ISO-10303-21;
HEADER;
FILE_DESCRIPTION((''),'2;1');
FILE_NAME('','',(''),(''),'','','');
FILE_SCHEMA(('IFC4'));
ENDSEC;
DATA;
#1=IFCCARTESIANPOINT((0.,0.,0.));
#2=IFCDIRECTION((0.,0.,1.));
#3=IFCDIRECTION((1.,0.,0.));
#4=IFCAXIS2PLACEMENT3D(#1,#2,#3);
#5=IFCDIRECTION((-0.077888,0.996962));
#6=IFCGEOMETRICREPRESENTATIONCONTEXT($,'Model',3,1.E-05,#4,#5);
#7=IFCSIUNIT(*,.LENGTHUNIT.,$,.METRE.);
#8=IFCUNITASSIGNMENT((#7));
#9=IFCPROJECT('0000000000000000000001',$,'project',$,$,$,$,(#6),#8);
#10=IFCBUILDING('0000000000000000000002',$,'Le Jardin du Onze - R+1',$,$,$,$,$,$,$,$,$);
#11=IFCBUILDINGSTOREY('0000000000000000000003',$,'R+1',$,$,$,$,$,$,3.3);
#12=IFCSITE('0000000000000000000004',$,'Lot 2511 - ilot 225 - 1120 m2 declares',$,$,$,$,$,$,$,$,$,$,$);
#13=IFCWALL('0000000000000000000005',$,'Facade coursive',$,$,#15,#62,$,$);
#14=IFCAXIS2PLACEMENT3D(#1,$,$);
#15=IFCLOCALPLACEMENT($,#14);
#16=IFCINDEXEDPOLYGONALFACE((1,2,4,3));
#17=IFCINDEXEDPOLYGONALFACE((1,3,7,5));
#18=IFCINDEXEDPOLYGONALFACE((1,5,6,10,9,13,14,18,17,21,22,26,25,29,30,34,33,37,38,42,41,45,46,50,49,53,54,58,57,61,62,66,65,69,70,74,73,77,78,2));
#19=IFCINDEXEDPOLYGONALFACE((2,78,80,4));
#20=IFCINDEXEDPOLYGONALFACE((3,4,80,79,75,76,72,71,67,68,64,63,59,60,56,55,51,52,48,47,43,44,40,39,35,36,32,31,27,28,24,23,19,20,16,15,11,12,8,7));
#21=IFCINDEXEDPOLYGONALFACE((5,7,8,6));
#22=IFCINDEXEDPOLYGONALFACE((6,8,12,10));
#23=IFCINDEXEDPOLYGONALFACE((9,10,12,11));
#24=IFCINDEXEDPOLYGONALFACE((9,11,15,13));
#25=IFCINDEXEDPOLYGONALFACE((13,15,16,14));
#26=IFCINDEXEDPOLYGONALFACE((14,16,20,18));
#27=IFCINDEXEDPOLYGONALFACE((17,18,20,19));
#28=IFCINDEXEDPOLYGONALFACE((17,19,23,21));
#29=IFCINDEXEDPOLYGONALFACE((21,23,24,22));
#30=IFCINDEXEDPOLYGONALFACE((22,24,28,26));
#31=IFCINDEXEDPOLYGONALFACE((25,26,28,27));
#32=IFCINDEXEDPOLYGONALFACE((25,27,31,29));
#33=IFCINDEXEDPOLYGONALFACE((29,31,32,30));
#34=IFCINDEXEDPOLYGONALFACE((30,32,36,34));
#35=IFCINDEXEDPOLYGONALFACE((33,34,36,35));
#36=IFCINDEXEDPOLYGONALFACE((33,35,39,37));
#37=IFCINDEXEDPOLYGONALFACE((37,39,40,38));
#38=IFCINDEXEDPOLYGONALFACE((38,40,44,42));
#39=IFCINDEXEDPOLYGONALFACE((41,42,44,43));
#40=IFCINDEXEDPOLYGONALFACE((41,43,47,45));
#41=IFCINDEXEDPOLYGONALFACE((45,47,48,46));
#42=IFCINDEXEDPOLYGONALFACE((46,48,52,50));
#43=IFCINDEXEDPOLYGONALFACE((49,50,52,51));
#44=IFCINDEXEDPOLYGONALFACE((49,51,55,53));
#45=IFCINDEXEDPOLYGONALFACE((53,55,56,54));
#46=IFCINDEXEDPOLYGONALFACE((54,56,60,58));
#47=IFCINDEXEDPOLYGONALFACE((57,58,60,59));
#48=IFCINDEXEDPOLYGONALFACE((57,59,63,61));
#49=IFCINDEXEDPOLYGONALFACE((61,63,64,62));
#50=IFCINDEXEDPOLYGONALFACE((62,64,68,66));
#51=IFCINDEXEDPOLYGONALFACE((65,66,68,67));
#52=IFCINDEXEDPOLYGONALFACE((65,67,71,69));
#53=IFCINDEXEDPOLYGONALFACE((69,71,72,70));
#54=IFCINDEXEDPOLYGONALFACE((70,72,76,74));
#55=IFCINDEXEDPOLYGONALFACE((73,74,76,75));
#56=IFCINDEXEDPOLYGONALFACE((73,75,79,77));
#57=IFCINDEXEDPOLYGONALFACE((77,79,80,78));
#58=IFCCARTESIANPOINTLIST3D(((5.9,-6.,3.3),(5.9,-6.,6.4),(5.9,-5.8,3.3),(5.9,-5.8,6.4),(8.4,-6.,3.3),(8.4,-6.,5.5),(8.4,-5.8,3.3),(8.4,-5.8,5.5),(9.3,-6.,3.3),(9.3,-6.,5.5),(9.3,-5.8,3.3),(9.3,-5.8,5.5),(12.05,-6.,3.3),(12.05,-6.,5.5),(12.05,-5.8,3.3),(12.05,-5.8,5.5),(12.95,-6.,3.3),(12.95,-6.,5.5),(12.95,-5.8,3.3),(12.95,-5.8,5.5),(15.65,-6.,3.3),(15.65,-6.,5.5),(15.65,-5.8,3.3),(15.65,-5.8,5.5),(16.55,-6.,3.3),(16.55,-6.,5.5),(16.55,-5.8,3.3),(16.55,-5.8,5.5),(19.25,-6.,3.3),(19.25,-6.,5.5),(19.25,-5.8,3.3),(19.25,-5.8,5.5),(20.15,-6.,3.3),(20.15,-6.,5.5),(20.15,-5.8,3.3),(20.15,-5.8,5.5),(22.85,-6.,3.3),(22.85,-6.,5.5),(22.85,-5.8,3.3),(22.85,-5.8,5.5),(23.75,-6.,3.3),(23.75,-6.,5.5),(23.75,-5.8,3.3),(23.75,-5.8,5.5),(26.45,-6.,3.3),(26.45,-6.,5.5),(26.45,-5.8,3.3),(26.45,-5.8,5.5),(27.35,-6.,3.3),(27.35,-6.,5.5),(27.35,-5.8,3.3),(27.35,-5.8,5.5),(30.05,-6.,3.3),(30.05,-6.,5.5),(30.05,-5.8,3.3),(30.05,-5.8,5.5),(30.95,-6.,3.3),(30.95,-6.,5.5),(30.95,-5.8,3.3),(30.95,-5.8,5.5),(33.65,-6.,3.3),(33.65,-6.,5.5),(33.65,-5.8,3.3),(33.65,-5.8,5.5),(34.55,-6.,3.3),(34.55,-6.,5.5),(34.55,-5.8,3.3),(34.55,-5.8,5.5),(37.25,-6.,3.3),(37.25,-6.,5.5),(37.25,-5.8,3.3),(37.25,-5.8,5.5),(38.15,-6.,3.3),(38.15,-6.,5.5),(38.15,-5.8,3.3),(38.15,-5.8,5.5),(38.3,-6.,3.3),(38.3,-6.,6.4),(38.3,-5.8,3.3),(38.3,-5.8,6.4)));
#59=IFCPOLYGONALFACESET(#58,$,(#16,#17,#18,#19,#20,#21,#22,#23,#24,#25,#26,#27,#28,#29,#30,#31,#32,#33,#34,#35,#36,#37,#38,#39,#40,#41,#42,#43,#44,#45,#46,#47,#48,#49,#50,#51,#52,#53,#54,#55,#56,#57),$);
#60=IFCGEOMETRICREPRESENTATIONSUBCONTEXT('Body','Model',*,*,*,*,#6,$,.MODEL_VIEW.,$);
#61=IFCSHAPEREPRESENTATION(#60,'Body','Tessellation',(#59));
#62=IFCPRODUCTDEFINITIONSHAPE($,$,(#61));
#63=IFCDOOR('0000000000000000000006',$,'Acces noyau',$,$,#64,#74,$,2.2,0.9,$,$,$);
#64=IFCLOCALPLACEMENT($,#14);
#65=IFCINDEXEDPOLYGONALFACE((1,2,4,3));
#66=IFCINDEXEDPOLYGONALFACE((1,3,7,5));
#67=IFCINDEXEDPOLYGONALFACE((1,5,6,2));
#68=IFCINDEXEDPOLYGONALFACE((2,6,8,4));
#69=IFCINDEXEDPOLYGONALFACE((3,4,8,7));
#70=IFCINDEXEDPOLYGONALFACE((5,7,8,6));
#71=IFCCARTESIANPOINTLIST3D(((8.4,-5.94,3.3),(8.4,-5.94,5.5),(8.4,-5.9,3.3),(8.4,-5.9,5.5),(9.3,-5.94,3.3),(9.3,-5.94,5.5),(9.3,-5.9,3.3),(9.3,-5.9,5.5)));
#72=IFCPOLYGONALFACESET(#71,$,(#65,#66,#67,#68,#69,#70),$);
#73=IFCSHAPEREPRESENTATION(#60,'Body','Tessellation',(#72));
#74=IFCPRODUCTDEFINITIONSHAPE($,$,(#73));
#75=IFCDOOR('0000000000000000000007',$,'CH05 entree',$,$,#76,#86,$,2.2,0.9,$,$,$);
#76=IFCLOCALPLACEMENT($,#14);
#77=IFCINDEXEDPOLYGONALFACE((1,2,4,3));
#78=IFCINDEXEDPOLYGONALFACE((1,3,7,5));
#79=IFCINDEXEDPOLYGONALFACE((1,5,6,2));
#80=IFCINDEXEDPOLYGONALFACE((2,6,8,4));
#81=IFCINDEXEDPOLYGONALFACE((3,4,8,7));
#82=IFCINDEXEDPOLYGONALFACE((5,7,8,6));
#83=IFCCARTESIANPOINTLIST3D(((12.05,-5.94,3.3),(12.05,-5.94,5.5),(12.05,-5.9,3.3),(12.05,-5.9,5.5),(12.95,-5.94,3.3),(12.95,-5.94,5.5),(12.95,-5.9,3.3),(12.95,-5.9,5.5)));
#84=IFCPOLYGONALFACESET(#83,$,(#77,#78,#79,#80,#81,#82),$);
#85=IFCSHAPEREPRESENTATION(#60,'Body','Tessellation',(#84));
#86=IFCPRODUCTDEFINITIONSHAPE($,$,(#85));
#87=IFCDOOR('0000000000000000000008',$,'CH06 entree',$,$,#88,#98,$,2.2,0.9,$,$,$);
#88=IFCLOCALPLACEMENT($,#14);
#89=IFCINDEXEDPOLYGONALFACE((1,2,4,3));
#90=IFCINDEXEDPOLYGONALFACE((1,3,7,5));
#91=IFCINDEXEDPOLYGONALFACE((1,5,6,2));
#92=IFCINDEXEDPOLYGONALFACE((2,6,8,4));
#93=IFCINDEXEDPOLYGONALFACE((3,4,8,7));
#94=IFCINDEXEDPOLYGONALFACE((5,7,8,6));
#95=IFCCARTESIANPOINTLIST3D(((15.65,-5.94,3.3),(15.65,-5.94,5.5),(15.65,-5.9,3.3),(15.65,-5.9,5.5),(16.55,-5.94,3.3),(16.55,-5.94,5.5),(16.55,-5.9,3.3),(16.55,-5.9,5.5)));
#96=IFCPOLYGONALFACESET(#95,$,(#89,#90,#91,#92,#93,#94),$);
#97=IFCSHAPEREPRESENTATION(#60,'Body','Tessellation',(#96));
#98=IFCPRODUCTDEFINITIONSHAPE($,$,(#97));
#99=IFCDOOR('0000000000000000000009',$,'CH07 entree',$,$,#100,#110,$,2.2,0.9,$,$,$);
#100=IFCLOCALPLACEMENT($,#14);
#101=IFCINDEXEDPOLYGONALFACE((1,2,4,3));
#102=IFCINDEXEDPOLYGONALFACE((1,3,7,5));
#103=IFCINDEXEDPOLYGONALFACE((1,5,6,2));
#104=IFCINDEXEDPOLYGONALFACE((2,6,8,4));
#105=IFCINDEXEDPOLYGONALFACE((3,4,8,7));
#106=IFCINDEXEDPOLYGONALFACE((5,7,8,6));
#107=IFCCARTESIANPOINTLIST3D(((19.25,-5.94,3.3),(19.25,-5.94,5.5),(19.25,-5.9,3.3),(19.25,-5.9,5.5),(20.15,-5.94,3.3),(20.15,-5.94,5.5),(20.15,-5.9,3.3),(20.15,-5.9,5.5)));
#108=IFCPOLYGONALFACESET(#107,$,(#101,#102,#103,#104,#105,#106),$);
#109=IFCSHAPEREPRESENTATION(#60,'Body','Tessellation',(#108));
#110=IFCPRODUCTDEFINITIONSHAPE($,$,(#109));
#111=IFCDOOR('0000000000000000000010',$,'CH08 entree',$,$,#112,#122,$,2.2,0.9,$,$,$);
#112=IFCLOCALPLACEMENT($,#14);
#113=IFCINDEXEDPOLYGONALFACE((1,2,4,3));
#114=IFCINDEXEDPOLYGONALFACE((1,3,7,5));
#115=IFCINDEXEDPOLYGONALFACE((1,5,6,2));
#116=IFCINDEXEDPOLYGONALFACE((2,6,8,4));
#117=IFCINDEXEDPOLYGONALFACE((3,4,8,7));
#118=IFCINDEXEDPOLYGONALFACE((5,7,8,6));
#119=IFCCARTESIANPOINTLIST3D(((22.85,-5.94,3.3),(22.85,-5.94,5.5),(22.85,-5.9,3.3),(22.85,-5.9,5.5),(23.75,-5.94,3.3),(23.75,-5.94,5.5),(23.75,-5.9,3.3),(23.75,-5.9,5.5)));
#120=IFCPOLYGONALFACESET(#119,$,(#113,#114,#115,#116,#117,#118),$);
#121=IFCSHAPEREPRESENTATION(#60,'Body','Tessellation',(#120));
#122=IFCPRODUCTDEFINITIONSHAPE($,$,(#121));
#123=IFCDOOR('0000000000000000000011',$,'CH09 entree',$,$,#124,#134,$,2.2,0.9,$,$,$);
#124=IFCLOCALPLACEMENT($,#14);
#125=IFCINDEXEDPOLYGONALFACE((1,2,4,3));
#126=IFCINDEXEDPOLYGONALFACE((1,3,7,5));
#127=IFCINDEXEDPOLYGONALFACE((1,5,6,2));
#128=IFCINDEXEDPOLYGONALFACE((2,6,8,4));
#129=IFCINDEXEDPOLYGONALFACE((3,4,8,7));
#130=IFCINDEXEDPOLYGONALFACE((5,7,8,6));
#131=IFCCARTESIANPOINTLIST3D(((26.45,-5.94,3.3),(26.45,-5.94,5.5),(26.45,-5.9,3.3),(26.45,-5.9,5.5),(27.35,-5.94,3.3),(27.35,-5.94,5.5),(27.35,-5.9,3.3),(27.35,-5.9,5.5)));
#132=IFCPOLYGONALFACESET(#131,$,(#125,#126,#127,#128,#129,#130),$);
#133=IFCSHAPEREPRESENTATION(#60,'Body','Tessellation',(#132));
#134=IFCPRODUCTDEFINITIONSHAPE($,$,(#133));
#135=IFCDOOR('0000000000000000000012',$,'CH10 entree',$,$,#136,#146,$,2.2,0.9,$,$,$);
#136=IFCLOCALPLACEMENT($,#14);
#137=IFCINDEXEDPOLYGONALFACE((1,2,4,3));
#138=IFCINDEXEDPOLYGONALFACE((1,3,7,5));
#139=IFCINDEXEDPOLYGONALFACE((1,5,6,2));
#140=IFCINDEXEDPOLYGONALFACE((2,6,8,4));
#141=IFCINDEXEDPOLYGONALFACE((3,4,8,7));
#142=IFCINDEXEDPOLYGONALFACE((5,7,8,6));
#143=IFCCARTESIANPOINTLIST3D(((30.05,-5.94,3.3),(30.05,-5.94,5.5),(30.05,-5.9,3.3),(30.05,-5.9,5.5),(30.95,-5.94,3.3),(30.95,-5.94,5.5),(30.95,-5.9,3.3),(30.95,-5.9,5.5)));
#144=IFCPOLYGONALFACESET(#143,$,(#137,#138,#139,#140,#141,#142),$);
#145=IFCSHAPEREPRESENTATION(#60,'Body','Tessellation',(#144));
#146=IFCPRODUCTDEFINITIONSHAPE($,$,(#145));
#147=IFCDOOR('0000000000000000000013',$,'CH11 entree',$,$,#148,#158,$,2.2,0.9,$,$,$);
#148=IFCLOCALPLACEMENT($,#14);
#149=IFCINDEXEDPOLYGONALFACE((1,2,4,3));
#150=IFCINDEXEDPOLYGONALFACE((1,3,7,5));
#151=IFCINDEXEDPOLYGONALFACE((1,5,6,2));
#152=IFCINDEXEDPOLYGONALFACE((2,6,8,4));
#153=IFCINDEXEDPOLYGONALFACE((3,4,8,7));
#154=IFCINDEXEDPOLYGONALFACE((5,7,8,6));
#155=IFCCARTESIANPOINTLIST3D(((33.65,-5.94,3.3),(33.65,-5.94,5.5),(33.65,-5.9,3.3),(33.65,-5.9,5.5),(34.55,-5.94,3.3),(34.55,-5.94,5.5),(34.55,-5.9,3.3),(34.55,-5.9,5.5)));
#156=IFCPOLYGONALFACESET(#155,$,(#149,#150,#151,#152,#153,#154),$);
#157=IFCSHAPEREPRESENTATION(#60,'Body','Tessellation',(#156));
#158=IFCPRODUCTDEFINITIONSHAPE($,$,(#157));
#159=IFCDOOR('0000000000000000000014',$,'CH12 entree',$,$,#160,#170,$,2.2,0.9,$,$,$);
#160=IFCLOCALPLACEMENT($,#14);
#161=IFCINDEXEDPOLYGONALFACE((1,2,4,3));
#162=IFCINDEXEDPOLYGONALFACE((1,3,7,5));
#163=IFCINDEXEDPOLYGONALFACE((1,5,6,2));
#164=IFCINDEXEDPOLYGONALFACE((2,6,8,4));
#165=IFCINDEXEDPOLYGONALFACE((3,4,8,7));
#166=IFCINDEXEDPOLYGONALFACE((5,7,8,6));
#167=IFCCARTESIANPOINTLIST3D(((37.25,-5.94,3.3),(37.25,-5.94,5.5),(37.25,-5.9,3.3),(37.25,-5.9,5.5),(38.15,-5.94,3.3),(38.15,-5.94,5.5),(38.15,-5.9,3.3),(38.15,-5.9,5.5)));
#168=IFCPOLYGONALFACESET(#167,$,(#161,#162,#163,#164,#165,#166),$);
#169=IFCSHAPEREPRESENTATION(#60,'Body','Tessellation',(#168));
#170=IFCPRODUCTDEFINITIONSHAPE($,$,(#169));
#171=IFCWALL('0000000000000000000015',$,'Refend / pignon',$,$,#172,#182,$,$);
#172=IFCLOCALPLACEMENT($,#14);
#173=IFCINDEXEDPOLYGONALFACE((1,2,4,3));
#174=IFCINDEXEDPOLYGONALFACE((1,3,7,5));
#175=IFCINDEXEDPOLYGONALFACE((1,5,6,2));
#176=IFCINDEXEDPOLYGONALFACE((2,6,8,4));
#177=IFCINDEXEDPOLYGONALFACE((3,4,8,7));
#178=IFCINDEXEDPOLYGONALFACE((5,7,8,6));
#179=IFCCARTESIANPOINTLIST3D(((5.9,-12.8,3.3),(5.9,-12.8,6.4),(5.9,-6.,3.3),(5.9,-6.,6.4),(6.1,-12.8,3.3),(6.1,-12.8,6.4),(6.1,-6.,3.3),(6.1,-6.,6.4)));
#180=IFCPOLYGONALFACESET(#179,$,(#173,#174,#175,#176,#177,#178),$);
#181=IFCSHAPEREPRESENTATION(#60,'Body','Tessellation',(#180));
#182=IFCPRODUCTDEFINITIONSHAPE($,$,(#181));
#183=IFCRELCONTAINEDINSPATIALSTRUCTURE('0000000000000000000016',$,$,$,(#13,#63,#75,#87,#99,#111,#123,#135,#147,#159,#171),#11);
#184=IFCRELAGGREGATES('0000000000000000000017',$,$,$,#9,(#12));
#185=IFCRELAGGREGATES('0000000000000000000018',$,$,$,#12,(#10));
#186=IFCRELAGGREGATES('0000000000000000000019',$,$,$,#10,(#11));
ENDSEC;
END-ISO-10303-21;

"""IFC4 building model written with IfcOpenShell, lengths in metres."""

from ifc_helpers import new_model, si_unit, direction, frame, origin_with_axes, place, context, subcontext, project, spatial, polyline, outline, extrude, element, fill, save


model = new_model("IFC4")

# Units and contexts
model_context = context("Model", 3, precision=1e-05, world=origin_with_axes(), true_north=direction((-0.077888, 0.996962)))
body_context = subcontext(model_context, "Body", "Model", "MODEL_VIEW")
ifc_project = project(units=[si_unit("LENGTHUNIT", "METRE")], contexts=[model_context])

# Site, building, storey
site = spatial("IfcSite", under=ifc_project, Name="Lot 2511 - ilot 225 - 1120 m2 declares")
building = spatial("IfcBuilding", under=site, Name="Le Jardin du Onze - R+1")
storey = spatial("IfcBuildingStorey", under=building, Name="R+1", Elevation=3.3)

# Wall, openings, doors
wall_1_placement = place(None, origin_with_axes())
wall_1 = element("IfcWall", 1, at=wall_1_placement, inside=storey, Name="Facade coursive", context=body_context, shape_type="SweptSolid", body=[
    extrude(outline(polyline([(38.3, -6.0), (38.3, -5.8), (5.9, -5.8), (5.9, -6.0), (38.3, -6.0)])), frame((0.0, 0.0, 3.3)), (0.0, 0.0, 1.0), 3.1),
])
opening_1_placement = place(None, origin_with_axes())
opening_1 = element("IfcOpeningElement", 2, at=opening_1_placement, cuts=wall_1, context=body_context, shape_type="SweptSolid", body=[
    extrude(outline(polyline([(9.3, -6.04), (9.3, -5.76), (8.4, -5.76), (8.4, -6.04), (9.3, -6.04)])), frame((0.0, 0.0, 3.3)), (0.0, 0.0, 1.0), 2.2),
])
opening_2_placement = place(None, origin_with_axes())
opening_2 = element("IfcOpeningElement", 3, at=opening_2_placement, cuts=wall_1, context=body_context, shape_type="SweptSolid", body=[
    extrude(outline(polyline([(12.95, -6.04), (12.95, -5.76), (12.05, -5.76), (12.05, -6.04), (12.95, -6.04)])), frame((0.0, 0.0, 3.3)), (0.0, 0.0, 1.0), 2.2),
])
opening_3_placement = place(None, origin_with_axes())
opening_3 = element("IfcOpeningElement", 4, at=opening_3_placement, cuts=wall_1, context=body_context, shape_type="SweptSolid", body=[
    extrude(outline(polyline([(16.55, -6.04), (16.55, -5.76), (15.65, -5.76), (15.65, -6.04), (16.55, -6.04)])), frame((0.0, 0.0, 3.3)), (0.0, 0.0, 1.0), 2.2),
])
opening_4_placement = place(None, origin_with_axes())
opening_4 = element("IfcOpeningElement", 5, at=opening_4_placement, cuts=wall_1, context=body_context, shape_type="SweptSolid", body=[
    extrude(outline(polyline([(20.15, -6.04), (20.15, -5.76), (19.25, -5.76), (19.25, -6.04), (20.15, -6.04)])), frame((0.0, 0.0, 3.3)), (0.0, 0.0, 1.0), 2.2),
])
opening_5_placement = place(None, origin_with_axes())
opening_5 = element("IfcOpeningElement", 6, at=opening_5_placement, cuts=wall_1, context=body_context, shape_type="SweptSolid", body=[
    extrude(outline(polyline([(23.75, -6.04), (23.75, -5.76), (22.85, -5.76), (22.85, -6.04), (23.75, -6.04)])), frame((0.0, 0.0, 3.3)), (0.0, 0.0, 1.0), 2.2),
])
opening_6_placement = place(None, origin_with_axes())
opening_6 = element("IfcOpeningElement", 7, at=opening_6_placement, cuts=wall_1, context=body_context, shape_type="SweptSolid", body=[
    extrude(outline(polyline([(27.35, -6.04), (27.35, -5.76), (26.45, -5.76), (26.45, -6.04), (27.35, -6.04)])), frame((0.0, 0.0, 3.3)), (0.0, 0.0, 1.0), 2.2),
])
opening_7_placement = place(None, origin_with_axes())
opening_7 = element("IfcOpeningElement", 8, at=opening_7_placement, cuts=wall_1, context=body_context, shape_type="SweptSolid", body=[
    extrude(outline(polyline([(30.95, -6.04), (30.95, -5.76), (30.05, -5.76), (30.05, -6.04), (30.95, -6.04)])), frame((0.0, 0.0, 3.3)), (0.0, 0.0, 1.0), 2.2),
])
opening_8_placement = place(None, origin_with_axes())
opening_8 = element("IfcOpeningElement", 9, at=opening_8_placement, cuts=wall_1, context=body_context, shape_type="SweptSolid", body=[
    extrude(outline(polyline([(34.55, -6.04), (34.55, -5.76), (33.65, -5.76), (33.65, -6.04), (34.55, -6.04)])), frame((0.0, 0.0, 3.3)), (0.0, 0.0, 1.0), 2.2),
])
opening_9_placement = place(None, origin_with_axes())
opening_9 = element("IfcOpeningElement", 10, at=opening_9_placement, cuts=wall_1, context=body_context, shape_type="SweptSolid", body=[
    extrude(outline(polyline([(38.15, -6.04), (38.15, -5.76), (37.25, -5.76), (37.25, -6.04), (38.15, -6.04)])), frame((0.0, 0.0, 3.3)), (0.0, 0.0, 1.0), 2.2),
])
door_1_placement = place(None, origin_with_axes())
door_1 = element("IfcDoor", 11, at=door_1_placement, inside=storey, Name="Acces noyau", OverallHeight=2.2, OverallWidth=0.9, context=body_context, shape_type="SweptSolid", body=[
    extrude(outline(polyline([(9.3, -5.94), (9.3, -5.9), (8.4, -5.9), (8.4, -5.94), (9.3, -5.94)])), frame((0.0, 0.0, 3.3)), (0.0, 0.0, 1.0), 2.2),
])
fill(opening_1, door_1)
door_2_placement = place(None, origin_with_axes())
door_2 = element("IfcDoor", 12, at=door_2_placement, inside=storey, Name="CH05 entree", OverallHeight=2.2, OverallWidth=0.9, context=body_context, shape_type="SweptSolid", body=[
    extrude(outline(polyline([(12.95, -5.94), (12.95, -5.9), (12.05, -5.9), (12.05, -5.94), (12.95, -5.94)])), frame((0.0, 0.0, 3.3)), (0.0, 0.0, 1.0), 2.2),
])
fill(opening_2, door_2)
door_3_placement = place(None, origin_with_axes())
door_3 = element("IfcDoor", 13, at=door_3_placement, inside=storey, Name="CH06 entree", OverallHeight=2.2, OverallWidth=0.9, context=body_context, shape_type="SweptSolid", body=[
    extrude(outline(polyline([(16.55, -5.94), (16.55, -5.9), (15.65, -5.9), (15.65, -5.94), (16.55, -5.94)])), frame((0.0, 0.0, 3.3)), (0.0, 0.0, 1.0), 2.2),
])
fill(opening_3, door_3)
door_4_placement = place(None, origin_with_axes())
door_4 = element("IfcDoor", 14, at=door_4_placement, inside=storey, Name="CH07 entree", OverallHeight=2.2, OverallWidth=0.9, context=body_context, shape_type="SweptSolid", body=[
    extrude(outline(polyline([(20.15, -5.94), (20.15, -5.9), (19.25, -5.9), (19.25, -5.94), (20.15, -5.94)])), frame((0.0, 0.0, 3.3)), (0.0, 0.0, 1.0), 2.2),
])
fill(opening_4, door_4)
door_5_placement = place(None, origin_with_axes())
door_5 = element("IfcDoor", 15, at=door_5_placement, inside=storey, Name="CH08 entree", OverallHeight=2.2, OverallWidth=0.9, context=body_context, shape_type="SweptSolid", body=[
    extrude(outline(polyline([(23.75, -5.94), (23.75, -5.9), (22.85, -5.9), (22.85, -5.94), (23.75, -5.94)])), frame((0.0, 0.0, 3.3)), (0.0, 0.0, 1.0), 2.2),
])
fill(opening_5, door_5)
door_6_placement = place(None, origin_with_axes())
door_6 = element("IfcDoor", 16, at=door_6_placement, inside=storey, Name="CH09 entree", OverallHeight=2.2, OverallWidth=0.9, context=body_context, shape_type="SweptSolid", body=[
    extrude(outline(polyline([(27.35, -5.94), (27.35, -5.9), (26.45, -5.9), (26.45, -5.94), (27.35, -5.94)])), frame((0.0, 0.0, 3.3)), (0.0, 0.0, 1.0), 2.2),
])
fill(opening_6, door_6)
door_7_placement = place(None, origin_with_axes())
door_7 = element("IfcDoor", 17, at=door_7_placement, inside=storey, Name="CH10 entree", OverallHeight=2.2, OverallWidth=0.9, context=body_context, shape_type="SweptSolid", body=[
    extrude(outline(polyline([(30.95, -5.94), (30.95, -5.9), (30.05, -5.9), (30.05, -5.94), (30.95, -5.94)])), frame((0.0, 0.0, 3.3)), (0.0, 0.0, 1.0), 2.2),
])
fill(opening_7, door_7)
door_8_placement = place(None, origin_with_axes())
door_8 = element("IfcDoor", 18, at=door_8_placement, inside=storey, Name="CH11 entree", OverallHeight=2.2, OverallWidth=0.9, context=body_context, shape_type="SweptSolid", body=[
    extrude(outline(polyline([(34.55, -5.94), (34.55, -5.9), (33.65, -5.9), (33.65, -5.94), (34.55, -5.94)])), frame((0.0, 0.0, 3.3)), (0.0, 0.0, 1.0), 2.2),
])
fill(opening_8, door_8)
door_9_placement = place(None, origin_with_axes())
door_9 = element("IfcDoor", 19, at=door_9_placement, inside=storey, Name="CH12 entree", OverallHeight=2.2, OverallWidth=0.9, context=body_context, shape_type="SweptSolid", body=[
    extrude(outline(polyline([(38.15, -5.94), (38.15, -5.9), (37.25, -5.9), (37.25, -5.94), (38.15, -5.94)])), frame((0.0, 0.0, 3.3)), (0.0, 0.0, 1.0), 2.2),
])
fill(opening_9, door_9)

# Wall
wall_2_placement = place(None, origin_with_axes())
element("IfcWall", 20, at=wall_2_placement, inside=storey, Name="Refend / pignon", context=body_context, shape_type="SweptSolid", body=[
    extrude(outline(polyline([(6.1, -12.8), (6.1, -6.0), (5.9, -6.0), (5.9, -12.8), (6.1, -12.8)])), frame((0.0, 0.0, 3.3)), (0.0, 0.0, 1.0), 3.1),
])

save(model, "model.ifc")
